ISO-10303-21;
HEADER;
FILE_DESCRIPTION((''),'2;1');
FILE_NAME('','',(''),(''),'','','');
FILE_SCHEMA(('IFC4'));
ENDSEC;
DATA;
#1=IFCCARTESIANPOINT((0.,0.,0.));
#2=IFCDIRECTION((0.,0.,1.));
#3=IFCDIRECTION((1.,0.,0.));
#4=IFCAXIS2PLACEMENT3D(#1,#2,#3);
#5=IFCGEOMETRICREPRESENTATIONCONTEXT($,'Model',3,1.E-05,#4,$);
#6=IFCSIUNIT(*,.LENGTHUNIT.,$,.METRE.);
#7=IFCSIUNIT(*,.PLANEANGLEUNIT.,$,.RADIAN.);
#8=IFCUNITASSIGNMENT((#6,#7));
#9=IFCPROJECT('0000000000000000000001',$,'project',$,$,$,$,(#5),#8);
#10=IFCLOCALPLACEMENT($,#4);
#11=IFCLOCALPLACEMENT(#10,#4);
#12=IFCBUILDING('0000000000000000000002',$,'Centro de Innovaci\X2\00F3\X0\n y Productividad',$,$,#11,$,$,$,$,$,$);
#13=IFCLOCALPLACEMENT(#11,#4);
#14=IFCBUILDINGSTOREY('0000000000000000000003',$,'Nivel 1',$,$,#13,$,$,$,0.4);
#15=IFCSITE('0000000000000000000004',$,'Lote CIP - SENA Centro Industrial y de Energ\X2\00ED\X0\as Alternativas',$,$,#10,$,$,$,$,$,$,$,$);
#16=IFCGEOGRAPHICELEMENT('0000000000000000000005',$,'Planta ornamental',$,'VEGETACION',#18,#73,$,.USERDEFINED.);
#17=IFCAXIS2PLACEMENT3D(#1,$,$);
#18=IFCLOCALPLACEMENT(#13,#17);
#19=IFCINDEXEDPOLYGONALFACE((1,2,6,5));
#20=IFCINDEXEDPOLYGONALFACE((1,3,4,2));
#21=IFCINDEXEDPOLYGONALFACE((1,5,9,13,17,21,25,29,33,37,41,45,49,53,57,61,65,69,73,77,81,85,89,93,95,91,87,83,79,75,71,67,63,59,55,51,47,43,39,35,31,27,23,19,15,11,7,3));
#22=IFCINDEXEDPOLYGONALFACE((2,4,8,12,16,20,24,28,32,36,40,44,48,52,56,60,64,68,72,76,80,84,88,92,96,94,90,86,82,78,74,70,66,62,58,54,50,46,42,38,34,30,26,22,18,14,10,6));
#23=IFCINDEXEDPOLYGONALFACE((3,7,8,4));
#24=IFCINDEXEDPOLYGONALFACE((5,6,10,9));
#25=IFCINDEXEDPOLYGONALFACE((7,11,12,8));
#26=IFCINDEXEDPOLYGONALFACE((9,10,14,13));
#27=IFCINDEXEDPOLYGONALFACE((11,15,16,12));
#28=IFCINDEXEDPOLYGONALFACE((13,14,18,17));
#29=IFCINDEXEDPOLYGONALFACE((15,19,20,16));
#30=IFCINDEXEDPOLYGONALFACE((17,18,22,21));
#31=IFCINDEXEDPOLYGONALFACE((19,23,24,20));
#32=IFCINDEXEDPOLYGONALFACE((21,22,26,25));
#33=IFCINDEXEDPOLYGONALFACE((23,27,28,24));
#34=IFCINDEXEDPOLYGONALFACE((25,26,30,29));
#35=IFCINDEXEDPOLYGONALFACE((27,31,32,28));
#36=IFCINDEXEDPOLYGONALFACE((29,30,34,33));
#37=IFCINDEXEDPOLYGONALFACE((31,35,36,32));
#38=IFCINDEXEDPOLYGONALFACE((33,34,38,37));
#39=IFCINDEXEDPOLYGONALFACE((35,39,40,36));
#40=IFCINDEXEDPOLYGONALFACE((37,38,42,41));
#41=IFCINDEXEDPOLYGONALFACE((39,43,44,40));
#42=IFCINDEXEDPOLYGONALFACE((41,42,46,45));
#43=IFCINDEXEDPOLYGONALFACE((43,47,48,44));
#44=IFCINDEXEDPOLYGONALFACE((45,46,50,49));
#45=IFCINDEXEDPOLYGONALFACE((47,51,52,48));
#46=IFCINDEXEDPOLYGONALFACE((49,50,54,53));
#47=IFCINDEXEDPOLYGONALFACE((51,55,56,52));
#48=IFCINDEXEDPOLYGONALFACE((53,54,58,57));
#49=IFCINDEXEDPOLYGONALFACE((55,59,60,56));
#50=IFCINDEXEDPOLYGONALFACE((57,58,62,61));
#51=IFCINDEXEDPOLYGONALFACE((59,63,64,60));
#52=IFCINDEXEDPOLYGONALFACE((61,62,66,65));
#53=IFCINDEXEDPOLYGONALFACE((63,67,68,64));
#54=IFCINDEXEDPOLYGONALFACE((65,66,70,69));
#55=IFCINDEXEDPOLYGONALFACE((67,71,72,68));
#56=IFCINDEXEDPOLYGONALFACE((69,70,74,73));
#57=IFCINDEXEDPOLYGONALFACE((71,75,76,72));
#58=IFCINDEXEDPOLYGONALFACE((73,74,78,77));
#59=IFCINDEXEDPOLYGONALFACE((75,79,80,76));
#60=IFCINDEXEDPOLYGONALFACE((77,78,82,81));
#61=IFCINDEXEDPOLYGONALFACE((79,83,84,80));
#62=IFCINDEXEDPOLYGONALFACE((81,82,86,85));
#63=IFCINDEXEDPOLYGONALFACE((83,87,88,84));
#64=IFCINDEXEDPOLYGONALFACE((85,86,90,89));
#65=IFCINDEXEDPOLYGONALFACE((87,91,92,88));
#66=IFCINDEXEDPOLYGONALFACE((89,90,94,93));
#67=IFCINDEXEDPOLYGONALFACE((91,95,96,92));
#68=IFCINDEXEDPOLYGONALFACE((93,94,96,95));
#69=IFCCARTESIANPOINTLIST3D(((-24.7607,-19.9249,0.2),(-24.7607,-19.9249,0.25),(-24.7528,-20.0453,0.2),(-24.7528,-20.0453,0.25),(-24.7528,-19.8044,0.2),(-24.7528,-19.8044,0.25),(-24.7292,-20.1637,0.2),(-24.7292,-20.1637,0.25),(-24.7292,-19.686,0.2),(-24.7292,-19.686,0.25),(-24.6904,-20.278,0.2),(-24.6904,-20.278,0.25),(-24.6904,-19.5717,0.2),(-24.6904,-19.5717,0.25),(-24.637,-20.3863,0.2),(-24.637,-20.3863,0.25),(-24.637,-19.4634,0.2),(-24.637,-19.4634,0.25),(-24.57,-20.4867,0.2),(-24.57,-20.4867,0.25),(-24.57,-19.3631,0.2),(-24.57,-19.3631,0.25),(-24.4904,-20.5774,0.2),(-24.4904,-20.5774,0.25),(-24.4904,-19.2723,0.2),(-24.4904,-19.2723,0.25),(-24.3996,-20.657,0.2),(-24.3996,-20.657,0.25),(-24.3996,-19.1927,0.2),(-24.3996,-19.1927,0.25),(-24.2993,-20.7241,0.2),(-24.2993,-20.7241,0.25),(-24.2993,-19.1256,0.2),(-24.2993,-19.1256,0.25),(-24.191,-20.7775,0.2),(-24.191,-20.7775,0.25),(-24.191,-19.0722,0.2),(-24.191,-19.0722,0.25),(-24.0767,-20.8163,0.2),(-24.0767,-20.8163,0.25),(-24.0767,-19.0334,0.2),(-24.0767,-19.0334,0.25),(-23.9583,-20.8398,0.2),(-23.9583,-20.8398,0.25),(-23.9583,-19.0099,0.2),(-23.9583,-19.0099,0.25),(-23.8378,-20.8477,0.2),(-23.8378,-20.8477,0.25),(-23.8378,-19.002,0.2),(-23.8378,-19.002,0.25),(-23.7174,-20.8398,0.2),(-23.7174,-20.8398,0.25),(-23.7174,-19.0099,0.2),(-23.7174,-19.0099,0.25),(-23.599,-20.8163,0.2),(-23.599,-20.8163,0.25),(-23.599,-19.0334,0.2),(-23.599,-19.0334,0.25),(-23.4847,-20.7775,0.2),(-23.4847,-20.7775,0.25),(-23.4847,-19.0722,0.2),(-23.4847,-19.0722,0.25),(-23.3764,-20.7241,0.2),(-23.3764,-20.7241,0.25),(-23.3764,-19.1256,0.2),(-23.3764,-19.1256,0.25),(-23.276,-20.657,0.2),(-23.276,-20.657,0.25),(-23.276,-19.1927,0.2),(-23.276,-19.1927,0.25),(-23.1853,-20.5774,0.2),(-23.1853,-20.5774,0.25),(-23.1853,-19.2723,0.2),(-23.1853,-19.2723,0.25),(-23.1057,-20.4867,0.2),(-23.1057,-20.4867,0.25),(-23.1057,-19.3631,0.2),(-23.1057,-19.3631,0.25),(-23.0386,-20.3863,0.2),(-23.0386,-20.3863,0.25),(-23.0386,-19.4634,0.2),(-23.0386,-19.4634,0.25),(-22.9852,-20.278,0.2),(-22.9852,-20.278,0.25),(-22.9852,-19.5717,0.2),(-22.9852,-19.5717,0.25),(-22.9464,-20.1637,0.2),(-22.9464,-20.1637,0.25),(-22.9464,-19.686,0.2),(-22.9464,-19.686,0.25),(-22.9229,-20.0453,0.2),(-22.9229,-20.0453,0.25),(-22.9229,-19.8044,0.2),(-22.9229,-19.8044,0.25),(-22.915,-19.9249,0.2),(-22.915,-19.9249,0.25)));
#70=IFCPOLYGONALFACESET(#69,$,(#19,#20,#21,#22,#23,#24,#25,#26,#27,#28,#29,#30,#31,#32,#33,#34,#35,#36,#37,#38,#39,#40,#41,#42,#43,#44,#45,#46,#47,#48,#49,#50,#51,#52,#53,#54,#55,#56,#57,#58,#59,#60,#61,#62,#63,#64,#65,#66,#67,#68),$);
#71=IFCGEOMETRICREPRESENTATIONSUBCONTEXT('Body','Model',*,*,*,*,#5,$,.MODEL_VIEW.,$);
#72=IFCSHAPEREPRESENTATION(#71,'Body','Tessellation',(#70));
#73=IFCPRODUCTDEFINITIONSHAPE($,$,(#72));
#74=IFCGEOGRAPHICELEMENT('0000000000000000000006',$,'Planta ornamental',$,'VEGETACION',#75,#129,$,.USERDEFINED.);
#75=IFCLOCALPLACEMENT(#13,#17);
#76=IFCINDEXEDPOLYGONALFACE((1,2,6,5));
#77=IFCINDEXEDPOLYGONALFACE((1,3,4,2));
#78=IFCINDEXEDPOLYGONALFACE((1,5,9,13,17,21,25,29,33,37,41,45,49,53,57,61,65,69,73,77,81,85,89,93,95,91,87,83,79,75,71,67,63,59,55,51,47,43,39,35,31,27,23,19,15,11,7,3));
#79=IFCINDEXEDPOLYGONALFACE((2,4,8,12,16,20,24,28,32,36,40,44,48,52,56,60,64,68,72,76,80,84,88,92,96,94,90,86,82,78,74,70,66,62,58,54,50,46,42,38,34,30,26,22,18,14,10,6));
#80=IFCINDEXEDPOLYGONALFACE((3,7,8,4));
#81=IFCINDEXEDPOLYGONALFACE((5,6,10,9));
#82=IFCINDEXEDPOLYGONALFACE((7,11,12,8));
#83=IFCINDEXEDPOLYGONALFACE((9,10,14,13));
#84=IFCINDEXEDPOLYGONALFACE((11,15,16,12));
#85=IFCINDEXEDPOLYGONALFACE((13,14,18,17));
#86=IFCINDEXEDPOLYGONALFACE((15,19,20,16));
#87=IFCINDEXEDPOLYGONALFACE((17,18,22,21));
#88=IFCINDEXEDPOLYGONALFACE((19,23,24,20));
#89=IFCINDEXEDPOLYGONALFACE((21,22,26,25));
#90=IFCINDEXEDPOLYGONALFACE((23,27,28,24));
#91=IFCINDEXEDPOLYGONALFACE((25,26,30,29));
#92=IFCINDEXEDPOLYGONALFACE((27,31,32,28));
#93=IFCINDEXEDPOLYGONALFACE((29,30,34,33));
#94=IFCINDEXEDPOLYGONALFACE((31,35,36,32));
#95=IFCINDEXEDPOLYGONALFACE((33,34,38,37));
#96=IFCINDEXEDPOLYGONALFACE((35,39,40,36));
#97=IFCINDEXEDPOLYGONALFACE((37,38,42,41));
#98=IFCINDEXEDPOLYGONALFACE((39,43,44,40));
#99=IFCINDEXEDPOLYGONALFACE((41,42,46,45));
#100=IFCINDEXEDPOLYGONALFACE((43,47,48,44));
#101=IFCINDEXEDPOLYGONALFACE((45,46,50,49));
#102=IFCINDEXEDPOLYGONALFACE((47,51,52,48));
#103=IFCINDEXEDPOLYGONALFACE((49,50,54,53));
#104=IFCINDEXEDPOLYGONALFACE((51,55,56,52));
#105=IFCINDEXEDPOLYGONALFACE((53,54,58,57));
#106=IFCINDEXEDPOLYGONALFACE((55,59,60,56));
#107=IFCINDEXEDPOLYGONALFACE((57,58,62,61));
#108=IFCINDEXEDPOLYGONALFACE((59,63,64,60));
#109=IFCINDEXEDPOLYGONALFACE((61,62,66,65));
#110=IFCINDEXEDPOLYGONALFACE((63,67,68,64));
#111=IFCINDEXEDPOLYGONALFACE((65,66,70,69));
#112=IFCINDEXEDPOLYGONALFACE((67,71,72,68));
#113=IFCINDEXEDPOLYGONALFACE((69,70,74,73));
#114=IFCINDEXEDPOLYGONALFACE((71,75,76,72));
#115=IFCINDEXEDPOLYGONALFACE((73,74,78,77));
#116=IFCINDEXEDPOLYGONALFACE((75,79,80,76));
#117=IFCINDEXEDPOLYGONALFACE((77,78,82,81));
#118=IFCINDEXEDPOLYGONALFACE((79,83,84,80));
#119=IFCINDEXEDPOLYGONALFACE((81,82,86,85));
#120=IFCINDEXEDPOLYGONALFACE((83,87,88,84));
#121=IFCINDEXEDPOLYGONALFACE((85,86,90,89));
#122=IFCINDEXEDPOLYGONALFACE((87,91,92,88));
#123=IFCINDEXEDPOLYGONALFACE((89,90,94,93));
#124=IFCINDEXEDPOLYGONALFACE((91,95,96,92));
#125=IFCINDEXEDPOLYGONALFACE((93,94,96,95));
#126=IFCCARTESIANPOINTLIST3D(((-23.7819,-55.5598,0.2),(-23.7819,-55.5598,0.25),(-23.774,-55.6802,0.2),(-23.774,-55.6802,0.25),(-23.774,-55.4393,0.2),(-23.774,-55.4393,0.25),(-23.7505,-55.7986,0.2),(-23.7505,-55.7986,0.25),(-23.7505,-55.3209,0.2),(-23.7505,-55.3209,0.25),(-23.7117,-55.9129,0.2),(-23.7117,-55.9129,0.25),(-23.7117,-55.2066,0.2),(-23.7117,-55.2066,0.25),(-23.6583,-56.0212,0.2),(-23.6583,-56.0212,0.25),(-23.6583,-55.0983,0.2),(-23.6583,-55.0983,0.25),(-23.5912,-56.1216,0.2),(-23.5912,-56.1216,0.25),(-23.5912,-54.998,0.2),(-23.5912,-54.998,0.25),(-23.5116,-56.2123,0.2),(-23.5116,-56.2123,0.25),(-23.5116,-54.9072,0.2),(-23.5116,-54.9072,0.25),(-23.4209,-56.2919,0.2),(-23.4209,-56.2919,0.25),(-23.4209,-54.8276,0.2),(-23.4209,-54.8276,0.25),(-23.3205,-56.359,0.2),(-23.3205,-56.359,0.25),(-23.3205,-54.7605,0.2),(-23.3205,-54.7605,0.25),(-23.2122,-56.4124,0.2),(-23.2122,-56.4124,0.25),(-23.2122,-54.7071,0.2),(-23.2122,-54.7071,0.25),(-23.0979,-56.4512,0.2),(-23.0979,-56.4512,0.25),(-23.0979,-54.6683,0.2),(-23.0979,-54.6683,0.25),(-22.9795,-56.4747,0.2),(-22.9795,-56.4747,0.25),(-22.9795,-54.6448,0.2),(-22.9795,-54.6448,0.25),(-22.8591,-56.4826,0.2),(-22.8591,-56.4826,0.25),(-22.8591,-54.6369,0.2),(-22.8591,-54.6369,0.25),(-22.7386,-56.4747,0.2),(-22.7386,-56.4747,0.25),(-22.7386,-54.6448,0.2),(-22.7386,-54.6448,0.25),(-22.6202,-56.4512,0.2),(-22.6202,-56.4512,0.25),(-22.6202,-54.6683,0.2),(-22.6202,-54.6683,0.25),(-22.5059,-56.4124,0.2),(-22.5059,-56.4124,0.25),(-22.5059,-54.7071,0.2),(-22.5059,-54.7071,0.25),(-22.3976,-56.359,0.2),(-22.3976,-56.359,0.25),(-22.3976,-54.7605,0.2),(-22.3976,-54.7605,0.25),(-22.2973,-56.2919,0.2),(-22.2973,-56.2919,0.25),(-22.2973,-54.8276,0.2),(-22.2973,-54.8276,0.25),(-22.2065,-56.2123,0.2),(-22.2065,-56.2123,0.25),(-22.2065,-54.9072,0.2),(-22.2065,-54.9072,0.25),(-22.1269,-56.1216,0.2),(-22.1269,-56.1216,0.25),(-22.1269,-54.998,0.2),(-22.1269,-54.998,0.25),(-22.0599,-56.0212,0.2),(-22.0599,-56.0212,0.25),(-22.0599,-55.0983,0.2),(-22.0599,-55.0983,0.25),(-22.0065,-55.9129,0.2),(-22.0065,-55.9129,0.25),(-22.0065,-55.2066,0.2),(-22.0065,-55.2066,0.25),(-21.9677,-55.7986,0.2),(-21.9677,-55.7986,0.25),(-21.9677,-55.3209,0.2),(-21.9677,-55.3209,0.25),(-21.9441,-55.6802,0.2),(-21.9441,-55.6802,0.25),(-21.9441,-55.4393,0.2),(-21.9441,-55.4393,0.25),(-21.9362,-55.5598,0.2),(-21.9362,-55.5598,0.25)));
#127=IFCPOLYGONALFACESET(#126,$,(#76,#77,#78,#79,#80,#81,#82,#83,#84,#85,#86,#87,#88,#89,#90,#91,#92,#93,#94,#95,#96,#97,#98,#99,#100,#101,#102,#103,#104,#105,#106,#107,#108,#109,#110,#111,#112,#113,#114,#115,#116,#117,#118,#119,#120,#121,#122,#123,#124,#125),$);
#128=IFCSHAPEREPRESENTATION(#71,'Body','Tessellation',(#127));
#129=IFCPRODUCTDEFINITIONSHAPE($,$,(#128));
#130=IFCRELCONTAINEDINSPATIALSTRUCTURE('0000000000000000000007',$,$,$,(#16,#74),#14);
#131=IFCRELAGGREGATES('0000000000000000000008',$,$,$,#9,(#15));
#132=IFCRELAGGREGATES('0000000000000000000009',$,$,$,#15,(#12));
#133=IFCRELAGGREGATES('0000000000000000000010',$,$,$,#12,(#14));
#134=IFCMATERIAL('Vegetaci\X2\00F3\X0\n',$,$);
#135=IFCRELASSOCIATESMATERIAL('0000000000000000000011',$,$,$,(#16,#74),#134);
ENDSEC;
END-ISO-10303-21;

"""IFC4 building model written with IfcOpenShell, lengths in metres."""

from ifc_helpers import new_model, si_unit, frame, origin_with_axes, place, context, subcontext, project, spatial, polyline, outline, extrude, material, element, save


model = new_model("IFC4")

# Units and contexts
model_context = context("Model", 3, precision=1e-05, world=origin_with_axes())
body_context = subcontext(model_context, "Body", "Model", "MODEL_VIEW")
ifc_project = project(units=[si_unit("LENGTHUNIT", "METRE"), si_unit("PLANEANGLEUNIT", "RADIAN")], contexts=[model_context])

# Site, building, storey
site_placement = place(None, origin_with_axes())
site = spatial("IfcSite", under=ifc_project, at=site_placement, Name="Lote CIP - SENA Centro Industrial y de Energías Alternativas")
building_placement = place(site_placement, origin_with_axes())
building = spatial("IfcBuilding", under=site, at=building_placement, Name="Centro de Innovación y Productividad")
storey_placement = place(building_placement, origin_with_axes())
storey = spatial("IfcBuildingStorey", under=building, at=storey_placement, Name="Nivel 1", Elevation=0.4)

# Geographic elements
ifc_material_1 = material(Name="Vegetación")
geographic_element_1_placement = place(storey_placement, origin_with_axes())
element("IfcGeographicElement", 1, at=geographic_element_1_placement, inside=storey, material=ifc_material_1, Name="Planta ornamental", ObjectType="VEGETACION", PredefinedType="USERDEFINED", context=body_context, shape_type="SweptSolid", body=[
    extrude(outline(polyline([(-22.915, -19.9249), (-22.9229, -20.0453), (-22.9464, -20.1637), (-22.9852, -20.278), (-23.0386, -20.3863), (-23.1057, -20.4867), (-23.1853, -20.5774), (-23.276, -20.657), (-23.3764, -20.7241), (-23.4847, -20.7775), (-23.599, -20.8163), (-23.7174, -20.8398), (-23.8378, -20.8477), (-23.9583, -20.8398), (-24.0767, -20.8163), (-24.191, -20.7775), (-24.2993, -20.7241), (-24.3996, -20.657), (-24.4904, -20.5774), (-24.57, -20.4867), (-24.637, -20.3863), (-24.6904, -20.278), (-24.7292, -20.1637), (-24.7528, -20.0453), (-24.7607, -19.9249), (-24.7528, -19.8044), (-24.7292, -19.686), (-24.6904, -19.5717), (-24.637, -19.4634), (-24.57, -19.3631), (-24.4904, -19.2723), (-24.3996, -19.1927), (-24.2993, -19.1256), (-24.191, -19.0722), (-24.0767, -19.0334), (-23.9583, -19.0099), (-23.8378, -19.002), (-23.7174, -19.0099), (-23.599, -19.0334), (-23.4847, -19.0722), (-23.3764, -19.1256), (-23.276, -19.1927), (-23.1853, -19.2723), (-23.1057, -19.3631), (-23.0386, -19.4634), (-22.9852, -19.5717), (-22.9464, -19.686), (-22.9229, -19.8044), (-22.915, -19.9249)])), frame((0.0, 0.0, 0.2)), (0.0, 0.0, 1.0), 0.05),
])
geographic_element_2_placement = place(storey_placement, origin_with_axes())
element("IfcGeographicElement", 2, at=geographic_element_2_placement, inside=storey, material=ifc_material_1, Name="Planta ornamental", ObjectType="VEGETACION", PredefinedType="USERDEFINED", context=body_context, shape_type="SweptSolid", body=[
    extrude(outline(polyline([(-21.9362, -55.5598), (-21.9441, -55.6802), (-21.9677, -55.7986), (-22.0065, -55.9129), (-22.0599, -56.0212), (-22.1269, -56.1216), (-22.2065, -56.2123), (-22.2973, -56.2919), (-22.3976, -56.359), (-22.5059, -56.4124), (-22.6202, -56.4512), (-22.7386, -56.4747), (-22.8591, -56.4826), (-22.9795, -56.4747), (-23.0979, -56.4512), (-23.2122, -56.4124), (-23.3205, -56.359), (-23.4209, -56.2919), (-23.5116, -56.2123), (-23.5912, -56.1216), (-23.6583, -56.0212), (-23.7117, -55.9129), (-23.7505, -55.7986), (-23.774, -55.6802), (-23.7819, -55.5598), (-23.774, -55.4393), (-23.7505, -55.3209), (-23.7117, -55.2066), (-23.6583, -55.0983), (-23.5912, -54.998), (-23.5116, -54.9072), (-23.4209, -54.8276), (-23.3205, -54.7605), (-23.2122, -54.7071), (-23.0979, -54.6683), (-22.9795, -54.6448), (-22.8591, -54.6369), (-22.7386, -54.6448), (-22.6202, -54.6683), (-22.5059, -54.7071), (-22.3976, -54.7605), (-22.2973, -54.8276), (-22.2065, -54.9072), (-22.1269, -54.998), (-22.0599, -55.0983), (-22.0065, -55.2066), (-21.9677, -55.3209), (-21.9441, -55.4393), (-21.9362, -55.5598)])), frame((0.0, 0.0, 0.2)), (0.0, 0.0, 1.0), 0.05),
])

save(model, "model.ifc")
